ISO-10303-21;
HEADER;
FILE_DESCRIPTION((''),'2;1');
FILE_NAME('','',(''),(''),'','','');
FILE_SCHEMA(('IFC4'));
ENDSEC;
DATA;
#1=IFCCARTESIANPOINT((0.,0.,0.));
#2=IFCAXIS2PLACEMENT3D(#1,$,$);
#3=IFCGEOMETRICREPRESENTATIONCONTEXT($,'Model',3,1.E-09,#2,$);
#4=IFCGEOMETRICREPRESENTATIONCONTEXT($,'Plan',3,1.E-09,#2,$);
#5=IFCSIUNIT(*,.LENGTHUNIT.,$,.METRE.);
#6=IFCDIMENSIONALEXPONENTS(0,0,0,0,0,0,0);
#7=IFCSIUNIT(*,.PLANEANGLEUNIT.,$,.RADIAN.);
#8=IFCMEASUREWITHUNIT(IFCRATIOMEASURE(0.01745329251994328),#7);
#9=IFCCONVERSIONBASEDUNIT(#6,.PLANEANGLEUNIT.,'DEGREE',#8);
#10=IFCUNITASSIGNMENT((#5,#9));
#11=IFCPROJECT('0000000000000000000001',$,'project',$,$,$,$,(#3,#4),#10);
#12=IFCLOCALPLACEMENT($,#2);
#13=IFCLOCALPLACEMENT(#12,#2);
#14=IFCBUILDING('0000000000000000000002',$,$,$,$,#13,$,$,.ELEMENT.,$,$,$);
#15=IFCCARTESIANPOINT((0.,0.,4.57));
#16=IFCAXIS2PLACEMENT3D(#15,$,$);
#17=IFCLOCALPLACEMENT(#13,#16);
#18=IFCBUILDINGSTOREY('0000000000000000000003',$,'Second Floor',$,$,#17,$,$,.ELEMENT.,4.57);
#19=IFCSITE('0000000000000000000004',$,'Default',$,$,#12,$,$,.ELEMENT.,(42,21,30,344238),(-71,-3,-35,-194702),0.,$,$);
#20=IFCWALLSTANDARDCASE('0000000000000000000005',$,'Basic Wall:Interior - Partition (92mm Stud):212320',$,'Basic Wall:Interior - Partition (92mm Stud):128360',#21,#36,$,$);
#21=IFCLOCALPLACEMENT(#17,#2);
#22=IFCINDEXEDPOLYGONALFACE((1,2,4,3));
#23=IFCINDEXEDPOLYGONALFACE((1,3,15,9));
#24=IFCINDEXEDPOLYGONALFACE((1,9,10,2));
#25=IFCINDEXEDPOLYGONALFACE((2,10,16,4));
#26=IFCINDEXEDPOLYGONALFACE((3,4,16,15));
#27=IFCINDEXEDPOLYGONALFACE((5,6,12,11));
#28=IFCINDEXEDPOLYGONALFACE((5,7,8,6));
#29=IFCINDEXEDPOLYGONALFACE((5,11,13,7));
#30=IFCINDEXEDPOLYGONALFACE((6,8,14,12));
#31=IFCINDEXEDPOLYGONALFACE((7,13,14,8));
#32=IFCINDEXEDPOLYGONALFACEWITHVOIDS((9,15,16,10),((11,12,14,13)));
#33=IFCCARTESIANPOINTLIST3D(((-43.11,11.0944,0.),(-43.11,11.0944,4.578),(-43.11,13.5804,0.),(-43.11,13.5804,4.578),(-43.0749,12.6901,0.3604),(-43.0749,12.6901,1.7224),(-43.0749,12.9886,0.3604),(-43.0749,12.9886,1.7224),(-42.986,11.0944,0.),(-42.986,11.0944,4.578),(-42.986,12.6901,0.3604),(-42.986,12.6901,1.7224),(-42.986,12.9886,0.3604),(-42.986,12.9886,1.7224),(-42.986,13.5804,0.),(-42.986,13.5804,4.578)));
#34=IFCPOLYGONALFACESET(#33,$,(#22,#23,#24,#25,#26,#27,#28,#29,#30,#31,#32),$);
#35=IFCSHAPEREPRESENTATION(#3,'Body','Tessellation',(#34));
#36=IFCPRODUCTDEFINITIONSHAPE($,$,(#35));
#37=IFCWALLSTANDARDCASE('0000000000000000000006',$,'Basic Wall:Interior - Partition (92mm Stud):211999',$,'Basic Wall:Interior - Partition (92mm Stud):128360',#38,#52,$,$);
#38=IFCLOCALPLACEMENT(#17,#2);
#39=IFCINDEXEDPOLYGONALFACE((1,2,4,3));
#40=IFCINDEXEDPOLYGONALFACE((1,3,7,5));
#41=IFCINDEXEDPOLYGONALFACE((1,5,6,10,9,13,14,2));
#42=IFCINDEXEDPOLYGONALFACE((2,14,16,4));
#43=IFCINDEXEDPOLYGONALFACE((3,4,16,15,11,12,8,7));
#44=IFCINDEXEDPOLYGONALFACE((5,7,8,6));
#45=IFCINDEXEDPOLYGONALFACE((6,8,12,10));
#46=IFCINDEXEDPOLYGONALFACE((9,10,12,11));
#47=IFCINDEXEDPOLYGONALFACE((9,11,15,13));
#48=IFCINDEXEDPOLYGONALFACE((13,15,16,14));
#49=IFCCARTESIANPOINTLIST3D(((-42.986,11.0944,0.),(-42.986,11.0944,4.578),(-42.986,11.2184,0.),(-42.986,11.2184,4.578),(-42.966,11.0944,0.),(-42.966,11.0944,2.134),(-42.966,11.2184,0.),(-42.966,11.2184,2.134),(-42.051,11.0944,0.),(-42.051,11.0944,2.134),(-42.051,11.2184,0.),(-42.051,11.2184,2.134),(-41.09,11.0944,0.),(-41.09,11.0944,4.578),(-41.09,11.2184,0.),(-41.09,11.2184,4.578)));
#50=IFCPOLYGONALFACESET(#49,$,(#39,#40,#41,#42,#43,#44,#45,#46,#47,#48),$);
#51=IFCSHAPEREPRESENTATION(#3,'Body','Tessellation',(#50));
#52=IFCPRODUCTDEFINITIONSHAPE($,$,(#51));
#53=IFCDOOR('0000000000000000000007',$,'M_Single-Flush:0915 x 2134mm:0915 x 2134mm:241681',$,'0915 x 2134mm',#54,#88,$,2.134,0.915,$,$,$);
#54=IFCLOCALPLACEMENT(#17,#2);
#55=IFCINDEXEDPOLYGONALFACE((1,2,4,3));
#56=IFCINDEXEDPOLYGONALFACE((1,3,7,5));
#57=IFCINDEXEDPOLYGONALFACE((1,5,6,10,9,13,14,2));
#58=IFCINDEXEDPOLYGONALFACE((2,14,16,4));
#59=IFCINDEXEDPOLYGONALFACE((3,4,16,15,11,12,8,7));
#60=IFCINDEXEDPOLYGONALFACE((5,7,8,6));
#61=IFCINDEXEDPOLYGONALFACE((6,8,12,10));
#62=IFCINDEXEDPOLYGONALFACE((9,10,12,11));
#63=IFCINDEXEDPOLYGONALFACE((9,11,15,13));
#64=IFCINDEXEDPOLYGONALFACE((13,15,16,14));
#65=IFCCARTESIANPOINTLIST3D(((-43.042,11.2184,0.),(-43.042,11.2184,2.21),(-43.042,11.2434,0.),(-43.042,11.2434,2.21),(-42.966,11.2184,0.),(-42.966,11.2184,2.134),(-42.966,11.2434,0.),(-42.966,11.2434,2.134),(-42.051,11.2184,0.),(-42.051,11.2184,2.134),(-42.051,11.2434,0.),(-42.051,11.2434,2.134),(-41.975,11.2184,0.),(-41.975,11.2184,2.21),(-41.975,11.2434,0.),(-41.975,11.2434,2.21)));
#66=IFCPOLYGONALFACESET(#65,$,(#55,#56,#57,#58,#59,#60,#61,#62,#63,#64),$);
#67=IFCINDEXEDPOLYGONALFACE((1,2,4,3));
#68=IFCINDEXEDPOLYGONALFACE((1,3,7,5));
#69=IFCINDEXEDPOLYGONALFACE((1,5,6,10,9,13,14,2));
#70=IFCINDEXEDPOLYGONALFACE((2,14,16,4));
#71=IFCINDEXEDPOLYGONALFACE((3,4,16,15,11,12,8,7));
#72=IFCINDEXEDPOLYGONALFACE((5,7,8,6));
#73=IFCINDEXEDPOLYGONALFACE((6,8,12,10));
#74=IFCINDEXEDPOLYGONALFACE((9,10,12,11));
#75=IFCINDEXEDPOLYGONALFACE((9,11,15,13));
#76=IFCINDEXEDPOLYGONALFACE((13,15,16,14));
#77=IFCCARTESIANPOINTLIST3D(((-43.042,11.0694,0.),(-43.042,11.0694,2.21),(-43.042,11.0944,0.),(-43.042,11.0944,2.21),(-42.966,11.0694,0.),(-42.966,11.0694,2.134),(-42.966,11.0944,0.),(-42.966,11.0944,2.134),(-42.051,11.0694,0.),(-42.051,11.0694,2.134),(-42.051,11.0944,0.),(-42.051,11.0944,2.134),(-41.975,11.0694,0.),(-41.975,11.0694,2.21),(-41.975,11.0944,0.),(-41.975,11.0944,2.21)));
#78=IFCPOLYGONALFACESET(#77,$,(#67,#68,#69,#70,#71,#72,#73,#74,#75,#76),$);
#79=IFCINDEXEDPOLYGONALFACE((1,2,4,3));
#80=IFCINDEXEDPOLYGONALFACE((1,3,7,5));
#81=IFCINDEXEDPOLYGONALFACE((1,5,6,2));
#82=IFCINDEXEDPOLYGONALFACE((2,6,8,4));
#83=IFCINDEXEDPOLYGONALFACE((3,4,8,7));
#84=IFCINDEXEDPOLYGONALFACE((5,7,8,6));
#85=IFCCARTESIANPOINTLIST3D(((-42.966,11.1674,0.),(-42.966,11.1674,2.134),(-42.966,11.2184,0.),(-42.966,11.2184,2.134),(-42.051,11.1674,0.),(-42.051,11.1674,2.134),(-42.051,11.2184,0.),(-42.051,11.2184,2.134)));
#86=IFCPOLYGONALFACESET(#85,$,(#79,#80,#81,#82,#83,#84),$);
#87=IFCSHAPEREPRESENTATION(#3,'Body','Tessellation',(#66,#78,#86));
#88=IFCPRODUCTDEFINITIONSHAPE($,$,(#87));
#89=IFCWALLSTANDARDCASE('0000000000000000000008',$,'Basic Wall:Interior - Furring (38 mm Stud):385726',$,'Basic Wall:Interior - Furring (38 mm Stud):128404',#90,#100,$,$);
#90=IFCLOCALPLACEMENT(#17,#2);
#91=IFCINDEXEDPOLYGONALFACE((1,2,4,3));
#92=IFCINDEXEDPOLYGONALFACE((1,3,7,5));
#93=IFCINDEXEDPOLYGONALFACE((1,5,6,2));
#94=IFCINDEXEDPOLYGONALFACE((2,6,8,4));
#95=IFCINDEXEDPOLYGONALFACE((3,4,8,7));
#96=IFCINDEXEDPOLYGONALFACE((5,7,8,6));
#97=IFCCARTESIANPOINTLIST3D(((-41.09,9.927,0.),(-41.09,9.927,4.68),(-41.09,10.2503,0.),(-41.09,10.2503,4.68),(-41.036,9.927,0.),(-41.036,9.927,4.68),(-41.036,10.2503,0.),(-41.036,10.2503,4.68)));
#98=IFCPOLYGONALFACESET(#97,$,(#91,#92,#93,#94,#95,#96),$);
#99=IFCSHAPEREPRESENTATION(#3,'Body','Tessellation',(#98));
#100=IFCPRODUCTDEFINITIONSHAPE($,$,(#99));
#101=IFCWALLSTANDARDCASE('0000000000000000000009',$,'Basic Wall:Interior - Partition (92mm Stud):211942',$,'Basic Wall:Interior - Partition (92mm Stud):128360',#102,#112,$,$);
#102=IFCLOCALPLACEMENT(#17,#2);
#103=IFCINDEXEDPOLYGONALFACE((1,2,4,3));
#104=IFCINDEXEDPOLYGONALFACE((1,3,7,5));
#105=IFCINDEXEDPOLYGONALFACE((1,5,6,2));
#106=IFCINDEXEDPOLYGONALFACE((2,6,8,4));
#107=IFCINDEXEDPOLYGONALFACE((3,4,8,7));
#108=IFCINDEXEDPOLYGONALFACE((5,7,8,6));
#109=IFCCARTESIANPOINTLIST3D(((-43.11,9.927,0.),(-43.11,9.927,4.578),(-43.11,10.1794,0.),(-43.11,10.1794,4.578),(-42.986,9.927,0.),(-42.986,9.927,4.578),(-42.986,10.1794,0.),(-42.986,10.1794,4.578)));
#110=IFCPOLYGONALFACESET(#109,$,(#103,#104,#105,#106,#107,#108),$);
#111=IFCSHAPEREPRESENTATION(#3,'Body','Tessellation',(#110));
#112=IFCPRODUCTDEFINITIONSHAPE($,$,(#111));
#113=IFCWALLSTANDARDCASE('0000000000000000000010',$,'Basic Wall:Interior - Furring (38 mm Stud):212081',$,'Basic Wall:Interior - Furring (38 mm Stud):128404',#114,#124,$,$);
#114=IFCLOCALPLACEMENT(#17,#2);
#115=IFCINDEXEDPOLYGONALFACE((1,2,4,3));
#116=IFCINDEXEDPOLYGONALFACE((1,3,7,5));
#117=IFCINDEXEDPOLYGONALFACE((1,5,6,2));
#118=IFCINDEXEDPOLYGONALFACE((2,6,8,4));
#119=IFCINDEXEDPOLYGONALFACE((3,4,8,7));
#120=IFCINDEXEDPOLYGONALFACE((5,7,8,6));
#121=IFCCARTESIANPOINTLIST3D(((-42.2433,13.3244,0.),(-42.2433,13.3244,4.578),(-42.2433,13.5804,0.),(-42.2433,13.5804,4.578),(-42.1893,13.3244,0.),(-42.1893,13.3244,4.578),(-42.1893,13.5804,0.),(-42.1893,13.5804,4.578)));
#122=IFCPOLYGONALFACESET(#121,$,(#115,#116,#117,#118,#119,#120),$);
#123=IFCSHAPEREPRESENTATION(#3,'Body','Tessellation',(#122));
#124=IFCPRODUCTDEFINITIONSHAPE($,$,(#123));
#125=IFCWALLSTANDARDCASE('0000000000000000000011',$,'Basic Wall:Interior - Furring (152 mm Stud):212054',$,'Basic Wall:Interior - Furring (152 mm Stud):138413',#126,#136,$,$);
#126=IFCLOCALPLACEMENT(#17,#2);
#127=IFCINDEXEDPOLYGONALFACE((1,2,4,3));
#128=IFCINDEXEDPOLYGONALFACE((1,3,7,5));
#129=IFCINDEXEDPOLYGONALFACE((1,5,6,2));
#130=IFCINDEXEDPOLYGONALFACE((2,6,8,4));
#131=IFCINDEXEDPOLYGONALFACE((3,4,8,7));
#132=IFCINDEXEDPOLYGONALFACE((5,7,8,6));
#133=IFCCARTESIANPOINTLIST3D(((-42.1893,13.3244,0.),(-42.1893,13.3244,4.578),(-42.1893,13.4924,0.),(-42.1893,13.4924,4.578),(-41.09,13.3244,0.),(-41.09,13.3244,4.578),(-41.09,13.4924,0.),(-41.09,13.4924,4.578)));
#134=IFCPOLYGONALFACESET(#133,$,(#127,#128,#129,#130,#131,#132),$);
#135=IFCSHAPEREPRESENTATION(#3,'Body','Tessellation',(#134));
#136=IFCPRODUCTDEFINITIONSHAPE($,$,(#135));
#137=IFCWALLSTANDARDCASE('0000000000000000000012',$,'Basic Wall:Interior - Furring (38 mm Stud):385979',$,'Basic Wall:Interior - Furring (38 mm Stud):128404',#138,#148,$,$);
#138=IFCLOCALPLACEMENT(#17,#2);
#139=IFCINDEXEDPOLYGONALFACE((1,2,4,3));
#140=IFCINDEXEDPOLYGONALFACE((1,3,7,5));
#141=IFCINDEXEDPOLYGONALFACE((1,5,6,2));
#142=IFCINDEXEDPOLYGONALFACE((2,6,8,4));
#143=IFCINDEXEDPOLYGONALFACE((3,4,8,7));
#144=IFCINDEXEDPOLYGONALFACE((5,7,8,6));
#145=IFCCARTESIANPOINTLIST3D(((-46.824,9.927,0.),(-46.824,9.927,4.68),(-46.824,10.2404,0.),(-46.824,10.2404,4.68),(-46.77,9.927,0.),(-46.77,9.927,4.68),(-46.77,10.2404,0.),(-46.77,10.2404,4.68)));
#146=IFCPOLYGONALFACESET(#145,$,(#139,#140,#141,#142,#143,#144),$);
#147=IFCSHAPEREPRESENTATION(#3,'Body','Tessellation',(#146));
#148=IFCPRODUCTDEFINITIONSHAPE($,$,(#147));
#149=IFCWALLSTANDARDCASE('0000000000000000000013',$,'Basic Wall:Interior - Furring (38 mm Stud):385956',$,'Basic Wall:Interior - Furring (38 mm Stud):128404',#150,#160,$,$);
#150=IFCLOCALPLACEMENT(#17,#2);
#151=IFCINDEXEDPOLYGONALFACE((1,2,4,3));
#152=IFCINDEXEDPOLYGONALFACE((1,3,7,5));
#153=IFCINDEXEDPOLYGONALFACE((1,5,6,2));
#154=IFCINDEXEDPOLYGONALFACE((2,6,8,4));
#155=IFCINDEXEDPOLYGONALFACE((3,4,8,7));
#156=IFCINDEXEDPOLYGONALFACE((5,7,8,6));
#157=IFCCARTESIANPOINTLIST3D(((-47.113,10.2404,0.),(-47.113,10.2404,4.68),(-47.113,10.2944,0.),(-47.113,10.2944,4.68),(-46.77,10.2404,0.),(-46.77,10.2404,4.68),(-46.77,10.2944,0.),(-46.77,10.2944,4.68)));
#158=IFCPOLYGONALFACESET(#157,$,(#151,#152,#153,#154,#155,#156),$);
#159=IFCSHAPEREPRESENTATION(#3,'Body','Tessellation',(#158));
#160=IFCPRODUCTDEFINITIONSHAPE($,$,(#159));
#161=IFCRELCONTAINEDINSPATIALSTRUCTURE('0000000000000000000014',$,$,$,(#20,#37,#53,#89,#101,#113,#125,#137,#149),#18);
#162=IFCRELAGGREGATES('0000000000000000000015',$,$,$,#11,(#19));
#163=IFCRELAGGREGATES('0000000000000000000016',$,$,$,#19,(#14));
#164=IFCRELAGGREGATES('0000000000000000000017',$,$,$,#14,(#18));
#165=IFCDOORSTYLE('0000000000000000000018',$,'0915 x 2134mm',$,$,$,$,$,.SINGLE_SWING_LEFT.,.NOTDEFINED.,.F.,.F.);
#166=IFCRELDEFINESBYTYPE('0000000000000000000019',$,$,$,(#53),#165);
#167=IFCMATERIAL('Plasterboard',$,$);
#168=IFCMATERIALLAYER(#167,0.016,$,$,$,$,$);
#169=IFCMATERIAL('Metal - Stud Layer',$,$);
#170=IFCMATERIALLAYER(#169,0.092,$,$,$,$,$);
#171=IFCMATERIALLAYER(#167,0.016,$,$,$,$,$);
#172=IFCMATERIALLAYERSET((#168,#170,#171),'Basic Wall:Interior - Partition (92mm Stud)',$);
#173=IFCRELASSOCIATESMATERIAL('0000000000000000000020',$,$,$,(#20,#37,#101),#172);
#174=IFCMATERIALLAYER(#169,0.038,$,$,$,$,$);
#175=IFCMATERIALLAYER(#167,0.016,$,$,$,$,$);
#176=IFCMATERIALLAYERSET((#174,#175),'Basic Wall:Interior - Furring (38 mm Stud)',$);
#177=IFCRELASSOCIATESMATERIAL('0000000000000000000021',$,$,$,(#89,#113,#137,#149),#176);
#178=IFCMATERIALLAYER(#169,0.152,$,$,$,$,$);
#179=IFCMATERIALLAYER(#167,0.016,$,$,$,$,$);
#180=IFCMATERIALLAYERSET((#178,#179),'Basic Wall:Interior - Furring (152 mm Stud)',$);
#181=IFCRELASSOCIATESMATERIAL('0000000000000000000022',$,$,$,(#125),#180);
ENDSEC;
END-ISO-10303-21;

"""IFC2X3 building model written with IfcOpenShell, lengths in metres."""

from ifc_helpers import new_model, entity, si_unit, converted_unit, frame, frame_2d, origin, origin_2d_with_axis, place, context, project, spatial, polyline, rectangle, outline, extrude, source, transform, mapped, material, layer, layer_set, layer_usage, type_object, type_shapes, element, fill, save


model = new_model("IFC2X3")

# Units and contexts
model_context = context("Model", 3, precision=1e-09, world=origin())
plan_context = context("Plan", 3, precision=1e-09, world=origin())
ifc_project = project(units=[si_unit("LENGTHUNIT", "METRE"), converted_unit("PLANEANGLEUNIT", "DEGREE", entity("IfcRatioMeasure", 0.01745329251994328), si_unit("PLANEANGLEUNIT", "RADIAN"), dimensions=[0, 0, 0, 0, 0, 0, 0])], contexts=[model_context, plan_context])

# Site, building, storey
site_placement = place(None, origin())
site = spatial("IfcSite", under=ifc_project, at=site_placement, Name="Default", CompositionType="ELEMENT", RefLatitude=(42, 21, 30, 344238), RefLongitude=(-71, -3, -35, -194702), RefElevation=0.0)
building_placement = place(site_placement, origin())
building = spatial("IfcBuilding", under=site, at=building_placement, CompositionType="ELEMENT")
storey_placement = place(building_placement, frame((0.0, 0.0, 4.57)))
storey = spatial("IfcBuildingStorey", under=building, at=storey_placement, Name="Second Floor", CompositionType="ELEMENT", Elevation=4.57)

# Shared definitions
ifc_material_1 = material(Name="Metal - Stud Layer")
ifc_material_2 = material(Name="Plasterboard")

# Wall, opening
ifc_layer_1 = layer(ifc_material_2, 0.016)
ifc_layer_2 = layer(ifc_material_1, 0.092)
ifc_layer_3 = layer(ifc_material_2, 0.016)
ifc_layer_set_1 = layer_set([ifc_layer_1, ifc_layer_2, ifc_layer_3], Name="Basic Wall:Interior - Partition (92mm Stud)")
ifc_layer_usage_1 = layer_usage(ifc_layer_set_1, "AXIS2", "NEGATIVE", 0.062)
wall_1_placement = place(storey_placement, frame((-43.048, 11.0944, 0.0), z_axis=(0.0, 0.0, 1.0), x_axis=(0.0, 1.0, 0.0)))
wall_1 = element("IfcWallStandardCase", 1, at=wall_1_placement, inside=storey, material=ifc_layer_usage_1, Name="Basic Wall:Interior - Partition (92mm Stud):212320", ObjectType="Basic Wall:Interior - Partition (92mm Stud):128360", context=model_context, shape_type="SweptSolid", body=[
    extrude(rectangle(XDim=2.486, YDim=0.124, at=frame_2d((1.243, 0.0), x_axis=(-1.0, 0.0))), origin(), (0.0, 0.0, 1.0), 4.578),
])
opening_1_placement = place(wall_1_placement, origin())
element("IfcOpeningElement", 2, at=opening_1_placement, cuts=wall_1, ObjectType="Opening", context=model_context, shape_type="SweptSolid", body=[
    extrude(rectangle(XDim=1.3621, YDim=0.2984, at=origin_2d_with_axis()), frame((1.7449, -0.1255, 1.0414), z_axis=(0.0, 1.0, 0.0), x_axis=(0.0, 0.0, -1.0)), (0.0, 0.0, 1.0), 0.1524),
])

# Wall, opening, door
wall_2_placement = place(storey_placement, frame((-41.09, 11.1564, 0.0), z_axis=(0.0, 0.0, 1.0), x_axis=(-1.0, 0.0, 0.0)))
wall_2 = element("IfcWallStandardCase", 3, at=wall_2_placement, inside=storey, material=ifc_layer_usage_1, Name="Basic Wall:Interior - Partition (92mm Stud):211999", ObjectType="Basic Wall:Interior - Partition (92mm Stud):128360", context=model_context, shape_type="SweptSolid", body=[
    extrude(rectangle(XDim=1.896, YDim=0.124, at=frame_2d((0.948, 0.0), x_axis=(-1.0, 0.0))), origin(), (0.0, 0.0, 1.0), 4.578),
])
opening_2_placement = place(wall_2_placement, frame((1.876, 0.062, 0.0)))
opening_2 = element("IfcOpeningElement", 4, at=opening_2_placement, cuts=wall_2, ObjectType="Opening", context=model_context, shape_type="SweptSolid", body=[
    extrude(rectangle(XDim=0.915, YDim=2.134, at=frame_2d((1.067, 0.4575), x_axis=(0.0, -1.0))), frame((0.0, 0.0, 0.0), z_axis=(0.0, -1.0, 0.0), x_axis=(0.0, 0.0, 1.0)), (0.0, 0.0, 1.0), 0.124),
])
door_style_1 = type_object("IfcDoorStyle", Name="0915 x 2134mm", ConstructionType="NOTDEFINED", OperationType="SINGLE_SWING_LEFT", ParameterTakesPrecedence=False, Sizeable=False)
shared_shape_1 = source(origin(), model_context, "Body", "SweptSolid", [
    extrude(outline(polyline([(-0.5335, -1.124), (0.5335, -1.124), (0.5335, 1.086), (0.4575, 1.086), (0.4575, -1.048), (-0.4575, -1.048), (-0.4575, 1.086), (-0.5335, 1.086), (-0.5335, -1.124)])), frame((0.4575, 0.149, 1.086), z_axis=(0.0, -1.0, 0.0), x_axis=(-1.0, 0.0, 0.0)), (0.0, 0.0, 1.0), 0.025),
    extrude(outline(polyline([(-1.124, -0.5335), (1.086, -0.5335), (1.086, -0.4575), (-1.048, -0.4575), (-1.048, 0.4575), (1.086, 0.4575), (1.086, 0.5335), (-1.124, 0.5335), (-1.124, -0.5335)])), frame((0.4575, 0.0, 1.086), z_axis=(0.0, -1.0, 0.0), x_axis=(0.0, 0.0, -1.0)), (0.0, 0.0, 1.0), 0.025),
    extrude(rectangle(XDim=0.915, YDim=0.051, at=origin_2d_with_axis()), frame((0.4575, 0.0985, 0.0)), (0.0, 0.0, 1.0), 2.134),
])
type_shapes(door_style_1, [shared_shape_1])
door_1_placement = place(opening_2_placement, frame((0.0, 0.0, 0.0), z_axis=(0.0, 0.0, 1.0), x_axis=(-1.0, 0.0, 0.0)))
door_1 = element("IfcDoor", 5, at=door_1_placement, inside=storey, type_object=door_style_1, Name="M_Single-Flush:0915 x 2134mm:0915 x 2134mm:241681", ObjectType="0915 x 2134mm", OverallHeight=2.134, OverallWidth=0.915, context=model_context, shape_type="MappedRepresentation", body=[
    mapped(shared_shape_1, transform((0.0, 0.0, 0.0), scale=1.0)),
])
fill(opening_2, door_1)

# Walls
ifc_layer_4 = layer(ifc_material_1, 0.038)
ifc_layer_5 = layer(ifc_material_2, 0.016)
ifc_layer_set_2 = layer_set([ifc_layer_4, ifc_layer_5], Name="Basic Wall:Interior - Furring (38 mm Stud)")
ifc_layer_usage_2 = layer_usage(ifc_layer_set_2, "AXIS2", "NEGATIVE", 0.027)
wall_3_placement = place(storey_placement, frame((-41.063, 10.2503, 0.0), z_axis=(0.0, 0.0, 1.0), x_axis=(0.0, -1.0, 0.0)))
element("IfcWallStandardCase", 6, at=wall_3_placement, inside=storey, material=ifc_layer_usage_2, Name="Basic Wall:Interior - Furring (38 mm Stud):385726", ObjectType="Basic Wall:Interior - Furring (38 mm Stud):128404", context=model_context, shape_type="SweptSolid", body=[
    extrude(rectangle(XDim=0.3233, YDim=0.054, at=frame_2d((0.1617, 0.0), x_axis=(-1.0, 0.0))), origin(), (0.0, 0.0, 1.0), 4.68),
])
wall_4_placement = place(storey_placement, frame((-43.048, 9.927, 0.0), z_axis=(0.0, 0.0, 1.0), x_axis=(0.0, 1.0, 0.0)))
element("IfcWallStandardCase", 7, at=wall_4_placement, inside=storey, material=ifc_layer_usage_1, Name="Basic Wall:Interior - Partition (92mm Stud):211942", ObjectType="Basic Wall:Interior - Partition (92mm Stud):128360", context=model_context, shape_type="SweptSolid", body=[
    extrude(rectangle(XDim=0.2524, YDim=0.124, at=frame_2d((0.1262, 0.0), x_axis=(-1.0, 0.0))), origin(), (0.0, 0.0, 1.0), 4.578),
])
ifc_layer_usage_3 = layer_usage(ifc_layer_set_2, "AXIS2", "POSITIVE", -0.027)
wall_5_placement = place(storey_placement, frame((-42.2163, 13.3244, 0.0), z_axis=(0.0, 0.0, 1.0), x_axis=(0.0, 1.0, 0.0)))
element("IfcWallStandardCase", 8, at=wall_5_placement, inside=storey, material=ifc_layer_usage_3, Name="Basic Wall:Interior - Furring (38 mm Stud):212081", ObjectType="Basic Wall:Interior - Furring (38 mm Stud):128404", context=model_context, shape_type="SweptSolid", body=[
    extrude(rectangle(XDim=0.256, YDim=0.054, at=frame_2d((0.128, 0.0), x_axis=(-1.0, 0.0))), origin(), (0.0, 0.0, 1.0), 4.578),
])
ifc_layer_6 = layer(ifc_material_1, 0.152)
ifc_layer_7 = layer(ifc_material_2, 0.016)
ifc_layer_set_3 = layer_set([ifc_layer_6, ifc_layer_7], Name="Basic Wall:Interior - Furring (152 mm Stud)")
ifc_layer_usage_4 = layer_usage(ifc_layer_set_3, "AXIS2", "POSITIVE", -0.084)
wall_6_placement = place(storey_placement, frame((-41.09, 13.4084, 0.0), z_axis=(0.0, 0.0, 1.0), x_axis=(-1.0, 0.0, 0.0)))
element("IfcWallStandardCase", 9, at=wall_6_placement, inside=storey, material=ifc_layer_usage_4, Name="Basic Wall:Interior - Furring (152 mm Stud):212054", ObjectType="Basic Wall:Interior - Furring (152 mm Stud):138413", context=model_context, shape_type="SweptSolid", body=[
    extrude(rectangle(XDim=1.0993, YDim=0.168, at=frame_2d((0.5497, 0.0), x_axis=(-1.0, 0.0))), origin(), (0.0, 0.0, 1.0), 4.578),
])
wall_7_placement = place(storey_placement, frame((-46.797, 10.2404, 0.0), z_axis=(0.0, 0.0, 1.0), x_axis=(0.0, -1.0, 0.0)))
element("IfcWallStandardCase", 10, at=wall_7_placement, inside=storey, material=ifc_layer_usage_3, Name="Basic Wall:Interior - Furring (38 mm Stud):385979", ObjectType="Basic Wall:Interior - Furring (38 mm Stud):128404", context=model_context, shape_type="SweptSolid", body=[
    extrude(rectangle(XDim=0.3134, YDim=0.054, at=frame_2d((0.1567, 0.0), x_axis=(-1.0, 0.0))), origin(), (0.0, 0.0, 1.0), 4.68),
])
wall_8_placement = place(storey_placement, frame((-47.113, 10.2674, 0.0)))
element("IfcWallStandardCase", 11, at=wall_8_placement, inside=storey, material=ifc_layer_usage_3, Name="Basic Wall:Interior - Furring (38 mm Stud):385956", ObjectType="Basic Wall:Interior - Furring (38 mm Stud):128404", context=model_context, shape_type="SweptSolid", body=[
    extrude(rectangle(XDim=0.343, YDim=0.054, at=frame_2d((0.1715, 0.0), x_axis=(-1.0, 0.0))), origin(), (0.0, 0.0, 1.0), 4.68),
])

save(model, "model.ifc")
